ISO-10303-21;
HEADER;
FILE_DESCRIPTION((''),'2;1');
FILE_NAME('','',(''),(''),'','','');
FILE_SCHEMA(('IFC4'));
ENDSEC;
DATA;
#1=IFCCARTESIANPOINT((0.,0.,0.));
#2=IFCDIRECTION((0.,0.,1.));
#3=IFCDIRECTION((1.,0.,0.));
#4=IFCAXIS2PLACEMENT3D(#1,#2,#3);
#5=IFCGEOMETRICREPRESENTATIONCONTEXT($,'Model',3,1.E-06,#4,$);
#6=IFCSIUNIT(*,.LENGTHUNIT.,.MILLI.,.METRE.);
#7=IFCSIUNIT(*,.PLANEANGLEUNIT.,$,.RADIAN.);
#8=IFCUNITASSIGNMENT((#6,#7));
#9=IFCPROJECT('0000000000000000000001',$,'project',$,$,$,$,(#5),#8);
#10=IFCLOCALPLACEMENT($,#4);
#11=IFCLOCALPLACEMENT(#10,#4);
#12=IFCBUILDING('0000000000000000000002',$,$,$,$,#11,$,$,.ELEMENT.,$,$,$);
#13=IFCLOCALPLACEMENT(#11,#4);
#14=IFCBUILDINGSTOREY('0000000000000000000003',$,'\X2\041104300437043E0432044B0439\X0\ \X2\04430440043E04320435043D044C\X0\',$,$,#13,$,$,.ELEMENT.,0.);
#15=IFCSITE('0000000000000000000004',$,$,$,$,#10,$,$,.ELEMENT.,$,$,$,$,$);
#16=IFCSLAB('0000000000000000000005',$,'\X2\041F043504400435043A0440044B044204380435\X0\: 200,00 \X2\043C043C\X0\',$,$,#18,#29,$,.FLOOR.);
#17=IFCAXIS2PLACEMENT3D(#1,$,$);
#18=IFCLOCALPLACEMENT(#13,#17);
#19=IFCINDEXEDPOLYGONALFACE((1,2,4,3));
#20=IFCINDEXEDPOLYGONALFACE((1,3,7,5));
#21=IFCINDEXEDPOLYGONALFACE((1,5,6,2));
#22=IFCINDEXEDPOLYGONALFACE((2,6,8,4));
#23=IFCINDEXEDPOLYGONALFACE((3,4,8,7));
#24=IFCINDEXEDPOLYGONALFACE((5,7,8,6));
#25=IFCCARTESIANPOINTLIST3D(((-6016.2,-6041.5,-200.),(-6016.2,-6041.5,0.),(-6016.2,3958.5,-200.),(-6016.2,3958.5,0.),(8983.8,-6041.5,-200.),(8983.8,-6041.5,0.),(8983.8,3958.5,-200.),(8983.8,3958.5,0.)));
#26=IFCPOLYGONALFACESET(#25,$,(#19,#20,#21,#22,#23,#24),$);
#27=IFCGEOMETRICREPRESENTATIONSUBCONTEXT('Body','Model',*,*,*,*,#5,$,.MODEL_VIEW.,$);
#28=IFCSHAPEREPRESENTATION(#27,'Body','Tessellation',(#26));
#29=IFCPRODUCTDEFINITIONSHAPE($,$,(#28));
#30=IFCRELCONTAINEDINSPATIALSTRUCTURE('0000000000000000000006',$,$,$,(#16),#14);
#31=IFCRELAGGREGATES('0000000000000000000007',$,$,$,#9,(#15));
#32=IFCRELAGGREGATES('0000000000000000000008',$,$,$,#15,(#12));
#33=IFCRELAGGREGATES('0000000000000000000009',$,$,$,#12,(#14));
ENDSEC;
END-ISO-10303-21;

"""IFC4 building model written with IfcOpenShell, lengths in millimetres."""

from ifc_helpers import new_model, si_unit, frame, origin_with_axes, place, context, subcontext, project, spatial, line, indexed_curve, outline, extrude, source, transform, mapped, element, save


model = new_model("IFC4")

# Units and contexts
model_context = context("Model", 3, precision=1e-06, world=origin_with_axes())
body_context = subcontext(model_context, "Body", "Model", "MODEL_VIEW")
ifc_project = project(units=[si_unit("LENGTHUNIT", "METRE", prefix="MILLI"), si_unit("PLANEANGLEUNIT", "RADIAN")], contexts=[model_context])

# Site, building, storey
site_placement = place(None, origin_with_axes())
site = spatial("IfcSite", under=ifc_project, at=site_placement, CompositionType="ELEMENT")
building_placement = place(site_placement, origin_with_axes())
building = spatial("IfcBuilding", under=site, at=building_placement, CompositionType="ELEMENT")
storey_placement = place(building_placement, origin_with_axes())
storey = spatial("IfcBuildingStorey", under=building, at=storey_placement, Name="Базовый уровень", CompositionType="ELEMENT", Elevation=0.0)

# Slab
shared_shape = source(origin_with_axes(), body_context, "Body", "SweptSolid", [
    extrude(outline(indexed_curve([(0.0, 0.0), (15000.0, 0.0), (15000.0, -10000.0), (0.0, -10000.0)], segments=[line(1, 2), line(2, 3), line(3, 4), line(4, 1)])), origin_with_axes(), (0.0, 0.0, 1.0), 200.0),
])
slab_placement = place(storey_placement, frame((-6016.2, 3958.5, -200.0), z_axis=(0.0, 0.0, 1.0), x_axis=(1.0, 0.0, 0.0)))
element("IfcSlab", 1, at=slab_placement, inside=storey, Name="Перекрытие: 200,00 мм", PredefinedType="FLOOR", context=body_context, shape_type="MappedRepresentation", body=[
    mapped(shared_shape, transform((0.0, 0.0, 0.0), x_axis=(1.0, 0.0, 0.0), y_axis=(0.0, 1.0, 0.0), z_axis=(0.0, 0.0, 1.0), scale=1.0)),
])

save(model, "model.ifc")
